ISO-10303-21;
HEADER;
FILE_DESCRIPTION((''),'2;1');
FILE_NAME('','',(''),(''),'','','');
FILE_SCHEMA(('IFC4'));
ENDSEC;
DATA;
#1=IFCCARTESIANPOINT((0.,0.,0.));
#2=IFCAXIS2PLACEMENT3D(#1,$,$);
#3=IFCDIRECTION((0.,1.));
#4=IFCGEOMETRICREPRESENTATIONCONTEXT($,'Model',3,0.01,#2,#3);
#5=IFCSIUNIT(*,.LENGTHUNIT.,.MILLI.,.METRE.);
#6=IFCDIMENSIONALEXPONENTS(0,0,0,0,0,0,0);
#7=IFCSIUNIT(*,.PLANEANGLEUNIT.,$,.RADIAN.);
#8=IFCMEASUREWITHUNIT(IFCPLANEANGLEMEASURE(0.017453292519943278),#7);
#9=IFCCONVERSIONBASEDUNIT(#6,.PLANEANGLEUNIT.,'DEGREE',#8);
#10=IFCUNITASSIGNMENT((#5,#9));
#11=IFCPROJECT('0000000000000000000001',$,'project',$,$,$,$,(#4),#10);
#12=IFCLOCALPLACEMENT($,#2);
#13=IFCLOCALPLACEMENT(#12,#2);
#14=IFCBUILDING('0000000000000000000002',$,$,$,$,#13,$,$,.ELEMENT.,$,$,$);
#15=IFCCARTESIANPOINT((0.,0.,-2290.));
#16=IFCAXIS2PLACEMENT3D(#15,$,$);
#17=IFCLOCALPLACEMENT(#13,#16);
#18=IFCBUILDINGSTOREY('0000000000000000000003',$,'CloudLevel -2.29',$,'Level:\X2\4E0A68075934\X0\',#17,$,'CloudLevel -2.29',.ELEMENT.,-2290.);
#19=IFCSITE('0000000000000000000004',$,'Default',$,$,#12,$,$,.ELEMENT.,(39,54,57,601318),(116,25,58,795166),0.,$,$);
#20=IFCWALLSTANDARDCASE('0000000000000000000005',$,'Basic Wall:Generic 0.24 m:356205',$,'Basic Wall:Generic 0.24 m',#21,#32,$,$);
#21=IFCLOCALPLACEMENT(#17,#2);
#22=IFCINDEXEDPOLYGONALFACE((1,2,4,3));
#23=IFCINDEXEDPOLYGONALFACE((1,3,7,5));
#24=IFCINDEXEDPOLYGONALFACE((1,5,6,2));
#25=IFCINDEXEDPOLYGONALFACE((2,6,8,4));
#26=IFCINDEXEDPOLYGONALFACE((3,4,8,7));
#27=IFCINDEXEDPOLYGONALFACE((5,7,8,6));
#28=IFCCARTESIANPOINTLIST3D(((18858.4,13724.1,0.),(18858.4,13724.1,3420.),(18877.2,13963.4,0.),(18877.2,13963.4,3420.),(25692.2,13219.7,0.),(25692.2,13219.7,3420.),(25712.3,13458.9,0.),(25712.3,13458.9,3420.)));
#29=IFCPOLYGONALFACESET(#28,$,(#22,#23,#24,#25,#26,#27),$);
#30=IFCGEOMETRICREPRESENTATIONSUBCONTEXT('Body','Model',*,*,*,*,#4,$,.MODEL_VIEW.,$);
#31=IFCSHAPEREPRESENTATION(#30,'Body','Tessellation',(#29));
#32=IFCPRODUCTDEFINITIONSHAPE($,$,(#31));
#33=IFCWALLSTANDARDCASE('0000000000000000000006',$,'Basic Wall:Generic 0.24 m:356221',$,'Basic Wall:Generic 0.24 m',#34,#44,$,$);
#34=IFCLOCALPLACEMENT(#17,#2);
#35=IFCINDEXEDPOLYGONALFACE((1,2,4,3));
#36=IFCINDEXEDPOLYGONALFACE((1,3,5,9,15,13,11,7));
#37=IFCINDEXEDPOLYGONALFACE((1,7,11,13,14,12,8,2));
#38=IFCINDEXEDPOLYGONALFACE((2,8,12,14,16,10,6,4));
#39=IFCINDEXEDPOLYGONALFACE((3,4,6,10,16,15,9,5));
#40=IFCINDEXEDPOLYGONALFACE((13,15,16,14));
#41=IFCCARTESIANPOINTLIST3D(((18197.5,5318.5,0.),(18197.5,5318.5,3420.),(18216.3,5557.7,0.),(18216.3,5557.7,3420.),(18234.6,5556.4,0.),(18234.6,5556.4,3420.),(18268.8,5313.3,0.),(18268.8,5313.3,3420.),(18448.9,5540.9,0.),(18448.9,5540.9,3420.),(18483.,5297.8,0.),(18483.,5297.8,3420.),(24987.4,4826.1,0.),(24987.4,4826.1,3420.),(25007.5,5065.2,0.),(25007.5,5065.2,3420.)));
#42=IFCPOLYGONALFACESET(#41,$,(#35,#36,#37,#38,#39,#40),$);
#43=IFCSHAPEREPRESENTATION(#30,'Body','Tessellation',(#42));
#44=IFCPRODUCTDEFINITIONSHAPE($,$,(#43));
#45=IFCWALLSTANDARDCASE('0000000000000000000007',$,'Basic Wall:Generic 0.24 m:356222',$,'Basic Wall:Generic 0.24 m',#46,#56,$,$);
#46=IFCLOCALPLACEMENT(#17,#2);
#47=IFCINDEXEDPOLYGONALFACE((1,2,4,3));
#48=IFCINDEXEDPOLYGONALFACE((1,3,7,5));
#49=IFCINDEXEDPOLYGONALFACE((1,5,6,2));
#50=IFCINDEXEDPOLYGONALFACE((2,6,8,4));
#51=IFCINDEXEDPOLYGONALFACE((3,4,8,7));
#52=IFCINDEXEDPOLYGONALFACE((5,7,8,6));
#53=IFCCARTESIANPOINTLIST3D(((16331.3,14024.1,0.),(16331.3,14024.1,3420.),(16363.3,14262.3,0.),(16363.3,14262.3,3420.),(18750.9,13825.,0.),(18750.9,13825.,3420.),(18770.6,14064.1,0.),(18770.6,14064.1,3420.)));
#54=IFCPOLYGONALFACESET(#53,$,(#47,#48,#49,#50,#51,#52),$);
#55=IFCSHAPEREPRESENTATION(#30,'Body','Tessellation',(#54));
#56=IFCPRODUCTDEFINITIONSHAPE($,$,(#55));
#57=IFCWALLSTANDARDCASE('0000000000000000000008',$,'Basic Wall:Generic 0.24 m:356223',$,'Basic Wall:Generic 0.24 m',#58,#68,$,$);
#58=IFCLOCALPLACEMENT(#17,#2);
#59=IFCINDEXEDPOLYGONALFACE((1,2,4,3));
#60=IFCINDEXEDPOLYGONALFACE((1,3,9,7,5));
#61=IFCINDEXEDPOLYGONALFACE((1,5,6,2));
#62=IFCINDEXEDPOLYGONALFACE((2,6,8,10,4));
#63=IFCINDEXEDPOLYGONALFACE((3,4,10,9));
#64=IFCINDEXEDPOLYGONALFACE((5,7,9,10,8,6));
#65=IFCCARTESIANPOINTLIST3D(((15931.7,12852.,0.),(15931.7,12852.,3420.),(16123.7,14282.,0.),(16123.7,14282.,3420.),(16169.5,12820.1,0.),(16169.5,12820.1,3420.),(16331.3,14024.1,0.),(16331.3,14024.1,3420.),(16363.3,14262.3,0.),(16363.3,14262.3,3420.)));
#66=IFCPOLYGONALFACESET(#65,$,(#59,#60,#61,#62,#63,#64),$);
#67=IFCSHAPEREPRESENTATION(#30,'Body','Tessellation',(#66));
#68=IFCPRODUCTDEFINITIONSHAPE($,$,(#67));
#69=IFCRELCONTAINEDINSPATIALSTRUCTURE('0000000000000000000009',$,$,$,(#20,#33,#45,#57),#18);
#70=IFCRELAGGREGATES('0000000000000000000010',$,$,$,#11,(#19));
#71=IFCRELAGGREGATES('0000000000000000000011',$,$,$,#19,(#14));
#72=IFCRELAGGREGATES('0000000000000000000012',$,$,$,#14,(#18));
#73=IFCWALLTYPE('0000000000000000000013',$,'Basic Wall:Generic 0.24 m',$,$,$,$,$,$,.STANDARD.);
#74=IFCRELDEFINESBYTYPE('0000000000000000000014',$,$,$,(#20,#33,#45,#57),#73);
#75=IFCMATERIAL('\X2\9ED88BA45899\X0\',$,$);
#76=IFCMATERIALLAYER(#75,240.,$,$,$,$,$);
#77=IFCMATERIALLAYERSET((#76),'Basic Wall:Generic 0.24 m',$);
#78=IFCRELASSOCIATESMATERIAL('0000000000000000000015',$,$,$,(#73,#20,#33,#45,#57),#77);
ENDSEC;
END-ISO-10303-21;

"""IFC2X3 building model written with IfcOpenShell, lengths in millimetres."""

from ifc_helpers import new_model, entity, si_unit, converted_unit, direction, frame, origin, place, context, subcontext, project, spatial, polyline, outline, extrude, material, layer, layer_set, layer_usage, type_object, element, save


model = new_model("IFC2X3")

# Units and contexts
model_context = context("Model", 3, precision=0.01, world=origin(), true_north=direction((0.0, 1.0)))
body_context = subcontext(model_context, "Body", "Model", "MODEL_VIEW")
ifc_project = project(units=[si_unit("LENGTHUNIT", "METRE", prefix="MILLI"), converted_unit("PLANEANGLEUNIT", "DEGREE", entity("IfcPlaneAngleMeasure", 0.017453292519943278), si_unit("PLANEANGLEUNIT", "RADIAN"), dimensions=[0, 0, 0, 0, 0, 0, 0])], contexts=[model_context])

# Site, building, storey
site_placement = place(None, origin())
site = spatial("IfcSite", under=ifc_project, at=site_placement, Name="Default", CompositionType="ELEMENT", RefLatitude=(39, 54, 57, 601318), RefLongitude=(116, 25, 58, 795166), RefElevation=0.0)
building_placement = place(site_placement, origin())
building = spatial("IfcBuilding", under=site, at=building_placement, CompositionType="ELEMENT")
storey_placement = place(building_placement, frame((0.0, 0.0, -2290.0)))
storey = spatial("IfcBuildingStorey", under=building, at=storey_placement, Name="CloudLevel -2.29", ObjectType="Level:上标头", LongName="CloudLevel -2.29", CompositionType="ELEMENT", Elevation=-2290.0)

# Shared definitions
ifc_material_1 = material(Name="默认墙")

# Walls
ifc_layer_1 = layer(ifc_material_1, 240.0)
ifc_layer_set_1 = layer_set([ifc_layer_1], Name="Basic Wall:Generic 0.24 m")
ifc_layer_usage_1 = layer_usage(ifc_layer_set_1, "AXIS2", "NEGATIVE", 120.0)
wall_type = type_object("IfcWallType", Name="Basic Wall:Generic 0.24 m", PredefinedType="STANDARD", material=ifc_layer_set_1)
wall_1_placement = place(storey_placement, frame((18867.2, 13843.8, 0.0), z_axis=(0.0, 0.0, 1.0), x_axis=(0.997287, -0.073607, 0.0)))
element("IfcWallStandardCase", 1, at=wall_1_placement, inside=storey, type_object=wall_type, material=ifc_layer_usage_1, Name="Basic Wall:Generic 0.24 m:356205", ObjectType="Basic Wall:Generic 0.24 m", context=body_context, shape_type="SweptSolid", body=[
    extrude(outline(polyline([(6852.4, -120.0), (6854.8, 120.0), (1.2, 120.0), (0.0, -120.0), (6852.4, -120.0)])), origin(), (0.0, 0.0, 1.0), 3420.0),
])
wall_2_placement = place(storey_placement, frame((18206.2, 5438.2, 0.0), z_axis=(0.0, 0.0, 1.0), x_axis=(0.997381, -0.072329, 0.0)))
element("IfcWallStandardCase", 2, at=wall_2_placement, inside=storey, type_object=wall_type, material=ifc_layer_usage_1, Name="Basic Wall:Generic 0.24 m:356221", ObjectType="Basic Wall:Generic 0.24 m", context=body_context, shape_type="SweptSolid", body=[
    extrude(outline(polyline([(6807.8, -120.0), (6810.5, 120.0), (234.7, 120.0), (19.8, 120.0), (1.5, 120.0), (0.0, -120.0), (71.5, -120.0), (286.3, -120.0), (6807.8, -120.0)])), origin(), (0.0, 0.0, 1.0), 3420.0),
])
wall_3_placement = place(storey_placement, frame((16341.1, 14143.7, 0.0), z_axis=(0.0, 0.0, 1.0), x_axis=(0.99663, -0.082025, 0.0)))
element("IfcWallStandardCase", 3, at=wall_3_placement, inside=storey, type_object=wall_type, material=ifc_layer_usage_1, Name="Basic Wall:Generic 0.24 m:356222", ObjectType="Basic Wall:Generic 0.24 m", context=body_context, shape_type="SweptSolid", body=[
    extrude(outline(polyline([(2427.8, -120.0), (2427.8, 120.0), (12.4, 120.0), (0.0, -120.0), (2427.8, -120.0)])), origin(), (0.0, 0.0, 1.0), 3420.0),
])
wall_4_placement = place(storey_placement, frame((16050.6, 12836.1, 0.0), z_axis=(0.0, 0.0, 1.0), x_axis=(0.133136, 0.991098, 0.0)))
element("IfcWallStandardCase", 4, at=wall_4_placement, inside=storey, type_object=wall_type, material=ifc_layer_usage_1, Name="Basic Wall:Generic 0.24 m:356223", ObjectType="Basic Wall:Generic 0.24 m", context=body_context, shape_type="SweptSolid", body=[
    extrude(outline(polyline([(1455.1, -120.0), (1442.8, 120.0), (0.0, 120.0), (0.0, -120.0), (1214.8, -120.0), (1455.1, -120.0)])), origin(), (0.0, 0.0, 1.0), 3420.0),
])

save(model, "model.ifc")
